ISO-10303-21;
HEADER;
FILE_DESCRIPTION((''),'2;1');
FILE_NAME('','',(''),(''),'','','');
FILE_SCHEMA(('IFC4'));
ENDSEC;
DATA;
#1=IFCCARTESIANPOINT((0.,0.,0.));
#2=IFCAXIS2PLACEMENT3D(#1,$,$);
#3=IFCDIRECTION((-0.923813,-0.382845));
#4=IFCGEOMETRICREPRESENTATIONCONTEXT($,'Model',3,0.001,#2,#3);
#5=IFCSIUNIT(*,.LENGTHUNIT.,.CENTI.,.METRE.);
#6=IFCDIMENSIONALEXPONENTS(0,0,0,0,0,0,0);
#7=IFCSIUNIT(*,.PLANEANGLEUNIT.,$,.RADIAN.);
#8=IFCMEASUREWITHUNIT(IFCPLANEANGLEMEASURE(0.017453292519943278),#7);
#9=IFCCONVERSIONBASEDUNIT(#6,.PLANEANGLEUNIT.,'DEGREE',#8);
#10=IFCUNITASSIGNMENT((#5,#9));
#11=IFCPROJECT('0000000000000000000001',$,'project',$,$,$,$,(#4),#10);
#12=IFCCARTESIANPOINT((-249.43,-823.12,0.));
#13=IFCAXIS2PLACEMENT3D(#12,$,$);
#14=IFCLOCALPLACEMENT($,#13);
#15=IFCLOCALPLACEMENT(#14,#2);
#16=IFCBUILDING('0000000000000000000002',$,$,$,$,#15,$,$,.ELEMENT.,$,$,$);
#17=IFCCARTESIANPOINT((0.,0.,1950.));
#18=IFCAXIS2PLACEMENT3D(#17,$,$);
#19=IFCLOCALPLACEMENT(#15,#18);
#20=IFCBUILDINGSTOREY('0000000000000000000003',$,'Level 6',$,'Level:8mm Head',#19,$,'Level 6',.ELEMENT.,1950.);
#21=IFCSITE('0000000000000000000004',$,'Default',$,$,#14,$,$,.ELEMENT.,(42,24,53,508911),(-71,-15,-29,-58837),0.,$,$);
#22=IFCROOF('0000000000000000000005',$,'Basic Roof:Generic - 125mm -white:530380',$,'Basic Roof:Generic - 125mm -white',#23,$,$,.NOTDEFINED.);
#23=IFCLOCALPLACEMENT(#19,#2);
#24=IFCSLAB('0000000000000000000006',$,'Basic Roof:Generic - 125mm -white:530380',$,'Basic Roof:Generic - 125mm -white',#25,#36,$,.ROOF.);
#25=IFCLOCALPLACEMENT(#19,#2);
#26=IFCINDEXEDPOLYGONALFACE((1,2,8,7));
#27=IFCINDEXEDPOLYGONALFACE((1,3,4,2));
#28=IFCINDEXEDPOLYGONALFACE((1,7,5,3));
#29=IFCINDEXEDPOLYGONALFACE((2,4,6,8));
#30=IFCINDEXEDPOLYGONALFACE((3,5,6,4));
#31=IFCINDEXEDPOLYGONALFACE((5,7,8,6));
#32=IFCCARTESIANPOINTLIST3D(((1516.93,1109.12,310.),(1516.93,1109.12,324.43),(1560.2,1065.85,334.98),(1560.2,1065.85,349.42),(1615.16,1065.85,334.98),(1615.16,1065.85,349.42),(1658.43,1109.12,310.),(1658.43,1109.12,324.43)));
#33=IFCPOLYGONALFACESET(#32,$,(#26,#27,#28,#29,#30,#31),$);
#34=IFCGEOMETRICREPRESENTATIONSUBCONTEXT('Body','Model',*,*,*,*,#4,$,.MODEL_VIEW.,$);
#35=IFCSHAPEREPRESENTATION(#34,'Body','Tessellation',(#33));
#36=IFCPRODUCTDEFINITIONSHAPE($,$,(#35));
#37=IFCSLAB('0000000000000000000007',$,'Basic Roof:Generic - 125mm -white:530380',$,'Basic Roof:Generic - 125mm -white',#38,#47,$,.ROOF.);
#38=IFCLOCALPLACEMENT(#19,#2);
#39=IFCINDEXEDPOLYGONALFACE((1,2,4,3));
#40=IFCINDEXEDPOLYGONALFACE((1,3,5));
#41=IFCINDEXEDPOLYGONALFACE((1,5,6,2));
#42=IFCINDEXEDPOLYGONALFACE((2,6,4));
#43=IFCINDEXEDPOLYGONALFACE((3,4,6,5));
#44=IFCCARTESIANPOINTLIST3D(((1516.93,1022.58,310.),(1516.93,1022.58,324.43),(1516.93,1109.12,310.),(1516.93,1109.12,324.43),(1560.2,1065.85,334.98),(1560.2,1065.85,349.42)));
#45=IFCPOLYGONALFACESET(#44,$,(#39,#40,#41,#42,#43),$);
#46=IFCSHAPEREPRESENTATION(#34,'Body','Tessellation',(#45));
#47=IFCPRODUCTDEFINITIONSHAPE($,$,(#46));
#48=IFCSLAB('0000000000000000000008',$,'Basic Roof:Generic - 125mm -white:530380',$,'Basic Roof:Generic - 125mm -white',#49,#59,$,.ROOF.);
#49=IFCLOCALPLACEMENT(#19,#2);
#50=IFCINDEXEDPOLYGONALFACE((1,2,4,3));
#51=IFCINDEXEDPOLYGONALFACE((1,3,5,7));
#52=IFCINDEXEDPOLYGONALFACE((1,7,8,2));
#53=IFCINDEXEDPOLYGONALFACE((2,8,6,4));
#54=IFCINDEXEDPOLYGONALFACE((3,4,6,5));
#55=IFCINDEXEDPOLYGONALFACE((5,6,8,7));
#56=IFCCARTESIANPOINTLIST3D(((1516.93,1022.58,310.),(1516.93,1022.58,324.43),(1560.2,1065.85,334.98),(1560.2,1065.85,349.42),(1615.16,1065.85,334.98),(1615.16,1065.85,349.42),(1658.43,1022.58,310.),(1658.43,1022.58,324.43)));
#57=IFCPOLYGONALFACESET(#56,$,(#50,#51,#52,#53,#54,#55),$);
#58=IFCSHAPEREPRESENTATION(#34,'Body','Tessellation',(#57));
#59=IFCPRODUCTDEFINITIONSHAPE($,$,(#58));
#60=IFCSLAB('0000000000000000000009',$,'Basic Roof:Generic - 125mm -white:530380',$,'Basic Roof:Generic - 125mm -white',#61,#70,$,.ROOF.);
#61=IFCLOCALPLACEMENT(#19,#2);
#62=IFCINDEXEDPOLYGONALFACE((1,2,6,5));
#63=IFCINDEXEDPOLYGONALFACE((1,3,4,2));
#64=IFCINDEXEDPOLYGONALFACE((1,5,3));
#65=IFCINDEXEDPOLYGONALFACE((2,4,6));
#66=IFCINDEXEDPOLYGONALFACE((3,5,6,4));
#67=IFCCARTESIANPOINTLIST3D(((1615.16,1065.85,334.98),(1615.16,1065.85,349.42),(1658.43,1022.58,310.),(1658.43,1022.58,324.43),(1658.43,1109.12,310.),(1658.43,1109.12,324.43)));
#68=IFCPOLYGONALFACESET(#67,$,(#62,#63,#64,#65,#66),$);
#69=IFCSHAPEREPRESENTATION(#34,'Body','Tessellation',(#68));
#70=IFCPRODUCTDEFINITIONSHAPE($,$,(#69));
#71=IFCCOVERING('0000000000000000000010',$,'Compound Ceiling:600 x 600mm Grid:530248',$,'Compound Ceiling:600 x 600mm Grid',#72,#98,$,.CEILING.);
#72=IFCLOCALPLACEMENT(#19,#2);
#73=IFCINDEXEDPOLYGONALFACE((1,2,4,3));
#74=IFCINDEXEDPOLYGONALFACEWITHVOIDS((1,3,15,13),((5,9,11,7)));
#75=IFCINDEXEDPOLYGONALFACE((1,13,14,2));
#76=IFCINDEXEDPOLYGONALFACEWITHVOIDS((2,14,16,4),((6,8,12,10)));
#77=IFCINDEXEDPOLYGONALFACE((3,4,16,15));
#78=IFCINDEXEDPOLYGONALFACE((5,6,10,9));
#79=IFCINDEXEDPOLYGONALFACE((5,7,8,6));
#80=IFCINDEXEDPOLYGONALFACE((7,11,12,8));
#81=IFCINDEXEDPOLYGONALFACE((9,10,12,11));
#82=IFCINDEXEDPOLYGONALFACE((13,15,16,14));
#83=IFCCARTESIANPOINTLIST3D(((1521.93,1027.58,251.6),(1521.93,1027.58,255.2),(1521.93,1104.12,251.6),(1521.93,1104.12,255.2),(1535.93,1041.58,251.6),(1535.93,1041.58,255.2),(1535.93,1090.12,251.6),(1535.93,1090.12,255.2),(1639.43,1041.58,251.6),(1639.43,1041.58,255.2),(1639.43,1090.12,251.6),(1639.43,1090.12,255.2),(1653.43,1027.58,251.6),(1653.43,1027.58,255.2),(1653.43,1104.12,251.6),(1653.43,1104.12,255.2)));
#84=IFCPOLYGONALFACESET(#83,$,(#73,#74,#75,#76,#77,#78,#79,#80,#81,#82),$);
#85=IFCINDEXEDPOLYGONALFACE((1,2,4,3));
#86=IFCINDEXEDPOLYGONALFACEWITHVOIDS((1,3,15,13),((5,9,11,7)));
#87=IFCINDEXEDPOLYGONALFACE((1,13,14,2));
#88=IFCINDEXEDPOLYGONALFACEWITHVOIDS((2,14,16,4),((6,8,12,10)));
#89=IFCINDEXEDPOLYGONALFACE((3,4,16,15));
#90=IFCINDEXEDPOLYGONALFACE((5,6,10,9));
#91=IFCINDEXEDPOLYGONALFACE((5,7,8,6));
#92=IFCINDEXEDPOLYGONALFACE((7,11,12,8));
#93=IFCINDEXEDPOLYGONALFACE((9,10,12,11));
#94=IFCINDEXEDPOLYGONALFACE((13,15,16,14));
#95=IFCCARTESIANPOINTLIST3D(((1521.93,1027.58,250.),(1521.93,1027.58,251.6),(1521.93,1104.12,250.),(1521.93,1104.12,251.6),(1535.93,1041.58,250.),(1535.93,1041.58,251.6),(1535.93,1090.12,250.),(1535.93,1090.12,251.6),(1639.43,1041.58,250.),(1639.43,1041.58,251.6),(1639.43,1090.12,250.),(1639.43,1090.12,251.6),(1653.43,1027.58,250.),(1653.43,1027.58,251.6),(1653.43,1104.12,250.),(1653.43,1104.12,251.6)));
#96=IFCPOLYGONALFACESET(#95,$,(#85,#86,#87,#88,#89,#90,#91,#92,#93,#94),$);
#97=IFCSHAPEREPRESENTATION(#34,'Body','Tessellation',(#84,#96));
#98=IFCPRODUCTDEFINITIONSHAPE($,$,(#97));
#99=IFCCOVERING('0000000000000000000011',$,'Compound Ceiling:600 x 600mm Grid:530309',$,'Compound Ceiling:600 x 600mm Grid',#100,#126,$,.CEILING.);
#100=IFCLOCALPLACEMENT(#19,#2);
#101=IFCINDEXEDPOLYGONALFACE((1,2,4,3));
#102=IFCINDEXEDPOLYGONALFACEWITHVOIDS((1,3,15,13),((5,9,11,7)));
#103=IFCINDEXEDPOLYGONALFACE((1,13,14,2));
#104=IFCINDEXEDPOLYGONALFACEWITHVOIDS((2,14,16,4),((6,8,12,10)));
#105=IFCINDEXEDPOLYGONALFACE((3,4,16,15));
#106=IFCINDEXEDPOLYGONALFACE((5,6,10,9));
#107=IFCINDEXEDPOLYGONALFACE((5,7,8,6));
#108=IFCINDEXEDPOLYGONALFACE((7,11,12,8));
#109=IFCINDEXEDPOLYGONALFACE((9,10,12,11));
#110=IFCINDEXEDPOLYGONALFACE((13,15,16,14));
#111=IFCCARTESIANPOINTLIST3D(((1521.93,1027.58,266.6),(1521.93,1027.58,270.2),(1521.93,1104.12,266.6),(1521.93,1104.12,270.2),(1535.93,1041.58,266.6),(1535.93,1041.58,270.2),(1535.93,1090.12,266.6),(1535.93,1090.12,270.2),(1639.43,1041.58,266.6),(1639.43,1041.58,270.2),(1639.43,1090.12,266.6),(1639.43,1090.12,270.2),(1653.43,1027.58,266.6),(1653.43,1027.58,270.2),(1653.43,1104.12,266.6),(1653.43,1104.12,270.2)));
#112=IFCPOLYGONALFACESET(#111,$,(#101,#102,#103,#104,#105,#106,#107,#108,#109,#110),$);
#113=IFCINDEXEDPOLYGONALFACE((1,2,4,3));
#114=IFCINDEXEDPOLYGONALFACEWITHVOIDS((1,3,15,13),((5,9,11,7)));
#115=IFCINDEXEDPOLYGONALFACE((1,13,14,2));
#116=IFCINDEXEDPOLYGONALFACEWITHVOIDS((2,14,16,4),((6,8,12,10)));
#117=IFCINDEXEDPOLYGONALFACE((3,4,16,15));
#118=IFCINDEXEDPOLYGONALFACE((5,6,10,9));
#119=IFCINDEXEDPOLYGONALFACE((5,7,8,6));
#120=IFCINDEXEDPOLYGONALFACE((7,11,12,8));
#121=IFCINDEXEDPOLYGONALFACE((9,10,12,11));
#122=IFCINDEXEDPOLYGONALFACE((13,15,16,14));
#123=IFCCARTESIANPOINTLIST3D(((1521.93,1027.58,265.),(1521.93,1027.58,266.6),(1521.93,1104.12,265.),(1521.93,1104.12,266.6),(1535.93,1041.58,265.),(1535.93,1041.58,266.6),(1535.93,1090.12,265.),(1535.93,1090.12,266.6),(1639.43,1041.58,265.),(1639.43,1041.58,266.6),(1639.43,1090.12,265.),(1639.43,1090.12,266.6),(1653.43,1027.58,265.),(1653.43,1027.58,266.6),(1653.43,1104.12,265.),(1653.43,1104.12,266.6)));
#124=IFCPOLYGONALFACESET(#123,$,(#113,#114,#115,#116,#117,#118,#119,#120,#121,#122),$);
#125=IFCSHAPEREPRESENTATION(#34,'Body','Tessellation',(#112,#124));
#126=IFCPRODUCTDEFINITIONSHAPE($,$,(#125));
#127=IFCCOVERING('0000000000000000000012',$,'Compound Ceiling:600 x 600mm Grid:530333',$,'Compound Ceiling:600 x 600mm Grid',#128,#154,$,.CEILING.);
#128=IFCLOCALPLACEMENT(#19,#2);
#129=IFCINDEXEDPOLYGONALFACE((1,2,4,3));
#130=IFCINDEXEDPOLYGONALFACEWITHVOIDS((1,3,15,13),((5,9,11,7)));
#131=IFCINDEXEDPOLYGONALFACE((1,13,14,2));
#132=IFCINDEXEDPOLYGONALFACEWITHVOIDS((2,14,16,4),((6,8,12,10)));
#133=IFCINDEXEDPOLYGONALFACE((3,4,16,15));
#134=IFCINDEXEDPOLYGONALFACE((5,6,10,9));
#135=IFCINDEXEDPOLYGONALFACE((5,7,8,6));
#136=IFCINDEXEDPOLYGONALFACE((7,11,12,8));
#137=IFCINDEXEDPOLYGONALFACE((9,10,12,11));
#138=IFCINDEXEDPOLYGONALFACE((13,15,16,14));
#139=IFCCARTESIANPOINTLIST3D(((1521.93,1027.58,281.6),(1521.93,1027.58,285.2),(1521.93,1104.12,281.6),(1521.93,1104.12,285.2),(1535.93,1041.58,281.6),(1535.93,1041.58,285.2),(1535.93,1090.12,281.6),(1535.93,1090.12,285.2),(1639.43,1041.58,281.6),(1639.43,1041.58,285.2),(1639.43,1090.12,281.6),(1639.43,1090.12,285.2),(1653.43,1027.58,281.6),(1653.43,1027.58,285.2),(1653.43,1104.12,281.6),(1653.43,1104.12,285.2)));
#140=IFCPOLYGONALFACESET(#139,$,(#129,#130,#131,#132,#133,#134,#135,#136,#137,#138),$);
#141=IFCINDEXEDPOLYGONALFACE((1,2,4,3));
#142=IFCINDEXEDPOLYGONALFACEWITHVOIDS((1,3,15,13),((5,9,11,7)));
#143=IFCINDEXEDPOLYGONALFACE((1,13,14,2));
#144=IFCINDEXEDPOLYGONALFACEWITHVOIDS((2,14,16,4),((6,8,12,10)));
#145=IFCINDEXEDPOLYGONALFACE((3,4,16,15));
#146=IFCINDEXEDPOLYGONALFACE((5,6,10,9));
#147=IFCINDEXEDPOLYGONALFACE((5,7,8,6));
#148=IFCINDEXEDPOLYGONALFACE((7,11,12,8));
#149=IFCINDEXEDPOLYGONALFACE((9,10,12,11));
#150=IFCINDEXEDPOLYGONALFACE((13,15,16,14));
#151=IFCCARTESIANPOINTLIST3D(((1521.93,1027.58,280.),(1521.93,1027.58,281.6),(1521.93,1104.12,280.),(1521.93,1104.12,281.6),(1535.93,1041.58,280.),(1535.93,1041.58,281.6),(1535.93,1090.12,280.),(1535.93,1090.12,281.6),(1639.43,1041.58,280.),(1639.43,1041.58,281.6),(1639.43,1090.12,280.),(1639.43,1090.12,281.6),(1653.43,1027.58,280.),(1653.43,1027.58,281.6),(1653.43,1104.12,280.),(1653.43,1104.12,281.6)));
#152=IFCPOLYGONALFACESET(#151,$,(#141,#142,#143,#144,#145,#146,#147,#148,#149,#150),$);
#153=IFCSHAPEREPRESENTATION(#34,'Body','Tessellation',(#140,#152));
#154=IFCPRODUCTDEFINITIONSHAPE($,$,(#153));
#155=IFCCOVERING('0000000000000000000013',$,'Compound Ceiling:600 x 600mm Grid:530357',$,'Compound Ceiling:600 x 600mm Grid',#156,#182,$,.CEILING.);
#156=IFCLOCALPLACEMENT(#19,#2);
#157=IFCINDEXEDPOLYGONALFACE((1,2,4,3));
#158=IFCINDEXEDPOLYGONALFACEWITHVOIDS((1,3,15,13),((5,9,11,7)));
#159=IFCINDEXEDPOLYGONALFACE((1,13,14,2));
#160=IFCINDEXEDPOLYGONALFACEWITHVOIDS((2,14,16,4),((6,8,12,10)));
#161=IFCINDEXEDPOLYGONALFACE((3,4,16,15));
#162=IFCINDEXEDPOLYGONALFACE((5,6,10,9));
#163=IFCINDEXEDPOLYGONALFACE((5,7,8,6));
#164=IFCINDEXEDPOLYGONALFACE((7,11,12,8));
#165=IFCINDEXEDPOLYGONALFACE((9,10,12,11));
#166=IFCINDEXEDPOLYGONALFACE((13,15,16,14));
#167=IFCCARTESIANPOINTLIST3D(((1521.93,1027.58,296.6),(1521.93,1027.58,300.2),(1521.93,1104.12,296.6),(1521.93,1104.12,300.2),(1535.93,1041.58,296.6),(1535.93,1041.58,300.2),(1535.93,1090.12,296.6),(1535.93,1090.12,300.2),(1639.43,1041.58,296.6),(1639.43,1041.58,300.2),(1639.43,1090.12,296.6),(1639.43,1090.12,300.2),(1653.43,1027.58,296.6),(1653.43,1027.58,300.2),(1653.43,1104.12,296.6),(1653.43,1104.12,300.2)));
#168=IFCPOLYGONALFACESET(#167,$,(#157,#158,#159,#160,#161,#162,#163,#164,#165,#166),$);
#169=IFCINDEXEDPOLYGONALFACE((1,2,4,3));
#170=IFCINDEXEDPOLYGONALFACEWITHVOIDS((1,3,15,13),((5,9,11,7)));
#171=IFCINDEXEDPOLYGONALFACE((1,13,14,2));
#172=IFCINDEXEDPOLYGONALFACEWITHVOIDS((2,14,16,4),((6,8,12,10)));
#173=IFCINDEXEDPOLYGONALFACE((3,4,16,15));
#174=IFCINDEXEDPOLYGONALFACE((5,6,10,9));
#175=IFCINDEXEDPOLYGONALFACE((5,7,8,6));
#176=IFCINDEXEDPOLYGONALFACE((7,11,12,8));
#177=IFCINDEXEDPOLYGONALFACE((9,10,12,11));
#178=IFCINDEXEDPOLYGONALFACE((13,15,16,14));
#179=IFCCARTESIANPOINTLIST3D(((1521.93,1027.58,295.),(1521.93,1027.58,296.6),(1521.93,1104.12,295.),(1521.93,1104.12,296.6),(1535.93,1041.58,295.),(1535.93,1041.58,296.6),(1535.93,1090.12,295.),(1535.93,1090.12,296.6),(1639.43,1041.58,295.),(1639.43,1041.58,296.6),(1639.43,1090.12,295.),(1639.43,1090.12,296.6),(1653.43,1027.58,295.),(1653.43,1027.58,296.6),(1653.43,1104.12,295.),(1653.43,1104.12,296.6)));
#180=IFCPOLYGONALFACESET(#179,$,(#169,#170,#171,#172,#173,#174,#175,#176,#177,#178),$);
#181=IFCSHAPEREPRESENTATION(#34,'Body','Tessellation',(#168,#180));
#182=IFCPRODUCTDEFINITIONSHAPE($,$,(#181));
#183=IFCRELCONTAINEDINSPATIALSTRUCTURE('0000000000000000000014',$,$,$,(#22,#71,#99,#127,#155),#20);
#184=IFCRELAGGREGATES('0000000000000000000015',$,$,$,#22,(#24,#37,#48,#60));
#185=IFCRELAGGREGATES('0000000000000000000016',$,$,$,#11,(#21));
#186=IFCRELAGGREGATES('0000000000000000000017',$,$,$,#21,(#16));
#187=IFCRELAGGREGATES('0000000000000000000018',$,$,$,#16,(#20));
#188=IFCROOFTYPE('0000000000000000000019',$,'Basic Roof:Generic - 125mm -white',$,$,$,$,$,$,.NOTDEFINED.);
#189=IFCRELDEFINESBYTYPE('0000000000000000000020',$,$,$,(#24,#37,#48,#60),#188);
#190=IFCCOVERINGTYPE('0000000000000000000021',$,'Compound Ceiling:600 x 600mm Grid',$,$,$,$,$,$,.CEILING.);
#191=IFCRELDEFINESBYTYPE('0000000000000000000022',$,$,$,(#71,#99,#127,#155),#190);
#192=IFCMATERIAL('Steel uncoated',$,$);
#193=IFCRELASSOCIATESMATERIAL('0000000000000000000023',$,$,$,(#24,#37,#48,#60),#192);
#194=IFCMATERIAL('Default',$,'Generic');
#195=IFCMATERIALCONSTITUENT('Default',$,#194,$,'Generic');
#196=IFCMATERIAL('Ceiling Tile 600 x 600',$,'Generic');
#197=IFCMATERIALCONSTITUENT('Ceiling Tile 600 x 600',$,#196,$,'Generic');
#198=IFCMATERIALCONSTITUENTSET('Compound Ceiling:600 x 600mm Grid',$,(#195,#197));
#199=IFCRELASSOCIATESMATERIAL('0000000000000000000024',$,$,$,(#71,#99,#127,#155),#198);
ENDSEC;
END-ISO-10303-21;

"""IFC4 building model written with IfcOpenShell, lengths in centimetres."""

from ifc_helpers import new_model, entity, si_unit, converted_unit, direction, frame, origin, place, context, subcontext, project, spatial, indexed_curve, outline, extrude, material, constituent, constituent_set, type_object, element, aggregate, save


model = new_model("IFC4")

# Units and contexts
model_context = context("Model", 3, precision=0.001, world=origin(), true_north=direction((-0.923813, -0.382845)))
body_context = subcontext(model_context, "Body", "Model", "MODEL_VIEW")
ifc_project = project(units=[si_unit("LENGTHUNIT", "METRE", prefix="CENTI"), converted_unit("PLANEANGLEUNIT", "DEGREE", entity("IfcPlaneAngleMeasure", 0.017453292519943278), si_unit("PLANEANGLEUNIT", "RADIAN"), dimensions=[0, 0, 0, 0, 0, 0, 0])], contexts=[model_context])

# Site, building, storey
site_placement = place(None, frame((-249.43, -823.12, 0.0)))
site = spatial("IfcSite", under=ifc_project, at=site_placement, Name="Default", CompositionType="ELEMENT", RefLatitude=(42, 24, 53, 508911), RefLongitude=(-71, -15, -29, -58837), RefElevation=0.0)
building_placement = place(site_placement, origin())
building = spatial("IfcBuilding", under=site, at=building_placement, CompositionType="ELEMENT")
storey_placement = place(building_placement, frame((0.0, 0.0, 1950.0)))
storey = spatial("IfcBuildingStorey", under=building, at=storey_placement, Name="Level 6", ObjectType="Level:8mm Head", LongName="Level 6", CompositionType="ELEMENT", Elevation=1950.0)

# Roof, slabs
roof_placement = place(storey_placement, frame((1516.93, 1022.58, 310.0)))
roof = element("IfcRoof", 1, at=roof_placement, inside=storey, Name="Basic Roof:Generic - 125mm -white:530380", ObjectType="Basic Roof:Generic - 125mm -white", PredefinedType="NOTDEFINED")
ifc_material_1 = material(Name="Steel uncoated")
roof_type = type_object("IfcRoofType", Name="Basic Roof:Generic - 125mm -white", PredefinedType="NOTDEFINED")
slab_1_placement = place(roof_placement, origin())
slab_1 = element("IfcSlab", 2, at=slab_1_placement, type_object=roof_type, material=ifc_material_1, Name="Basic Roof:Generic - 125mm -white:530380", ObjectType="Basic Roof:Generic - 125mm -white", PredefinedType="ROOF", context=body_context, shape_type="SweptSolid", body=[
    extrude(outline(indexed_curve([(70.75, 24.98), (-70.75, 24.98), (-27.48, -24.98), (27.48, -24.98), (70.75, 24.98)], self_intersect=False)), frame((70.75, 64.9, 12.49), z_axis=(0.0, 0.5, 0.866025), x_axis=(1.0, 0.0, 0.0)), (0.0, -0.5, 0.866025), 14.43),
])
slab_2_placement = place(roof_placement, origin())
slab_2 = element("IfcSlab", 3, at=slab_2_placement, type_object=roof_type, material=ifc_material_1, Name="Basic Roof:Generic - 125mm -white:530380", ObjectType="Basic Roof:Generic - 125mm -white", PredefinedType="ROOF", context=body_context, shape_type="SweptSolid", body=[
    extrude(outline(indexed_curve([(-24.98, 43.27), (-24.98, -43.27), (24.98, 0.0), (-24.98, 43.27)], self_intersect=False)), frame((21.64, 43.27, 12.49), z_axis=(-0.5, 0.0, 0.866025), x_axis=(0.866025, 0.0, 0.5)), (0.5, 0.0, 0.866025), 14.43),
])
slab_3_placement = place(roof_placement, origin())
slab_3 = element("IfcSlab", 4, at=slab_3_placement, type_object=roof_type, material=ifc_material_1, Name="Basic Roof:Generic - 125mm -white:530380", ObjectType="Basic Roof:Generic - 125mm -white", PredefinedType="ROOF", context=body_context, shape_type="SweptSolid", body=[
    extrude(outline(indexed_curve([(-70.75, -24.98), (70.75, -24.98), (27.48, 24.98), (-27.48, 24.98), (-70.75, -24.98)], self_intersect=False)), frame((70.75, 21.64, 12.49), z_axis=(0.0, -0.5, 0.866025), x_axis=(1.0, 0.0, 0.0)), (0.0, 0.5, 0.866025), 14.43),
])
slab_4_placement = place(roof_placement, origin())
slab_4 = element("IfcSlab", 5, at=slab_4_placement, type_object=roof_type, material=ifc_material_1, Name="Basic Roof:Generic - 125mm -white:530380", ObjectType="Basic Roof:Generic - 125mm -white", PredefinedType="ROOF", context=body_context, shape_type="SweptSolid", body=[
    extrude(outline(indexed_curve([(-24.98, 0.0), (24.98, -43.27), (24.98, 43.27), (-24.98, 0.0)], self_intersect=False)), frame((119.87, 43.27, 12.49), z_axis=(0.5, 0.0, 0.866025), x_axis=(0.866025, 0.0, -0.5)), (-0.5, 0.0, 0.866025), 14.43),
])
aggregate(roof, [slab_1, slab_2, slab_3, slab_4])

# Coverings
ifc_material_2 = material(Name="Default", Category="Generic")
ifc_constituent_1 = constituent(ifc_material_2, Name="Default", Category="Generic")
ifc_material_3 = material(Name="Ceiling Tile 600 x 600", Category="Generic")
ifc_constituent_2 = constituent(ifc_material_3, Name="Ceiling Tile 600 x 600", Category="Generic")
ifc_constituent_set_1 = constituent_set(constituents=[ifc_constituent_1, ifc_constituent_2], Name="Compound Ceiling:600 x 600mm Grid")
covering_type = type_object("IfcCoveringType", Name="Compound Ceiling:600 x 600mm Grid", PredefinedType="CEILING")
for number, where, name in (
    (6, (1521.93, 1027.58, 250.0), "Compound Ceiling:600 x 600mm Grid:530248"),
    (7, (1521.93, 1027.58, 265.0), "Compound Ceiling:600 x 600mm Grid:530309"),
    (8, (1521.93, 1027.58, 280.0), "Compound Ceiling:600 x 600mm Grid:530333"),
):
    element("IfcCovering", number, at=place(storey_placement, frame(where)), inside=storey, type_object=covering_type, material=ifc_constituent_set_1, Name=name, ObjectType="Compound Ceiling:600 x 600mm Grid", PredefinedType="CEILING", context=body_context, shape_type="SweptSolid", body=[
        extrude(outline(indexed_curve([(-38.27, -65.75), (38.27, -65.75), (38.27, 65.75), (-38.27, 65.75), (-38.27, -65.75)], self_intersect=False), holes=[indexed_curve([(24.27, -51.75), (-24.27, -51.75), (-24.27, 51.75), (24.27, 51.75), (24.27, -51.75)], self_intersect=False)]), frame((65.75, 38.27, 1.6), z_axis=(0.0, 0.0, 1.0), x_axis=(0.0, -1.0, 0.0)), (0.0, 0.0, 1.0), 3.6),
        extrude(outline(indexed_curve([(-65.75, -38.27), (65.75, -38.27), (65.75, 38.27), (-65.75, 38.27), (-65.75, -38.27)], self_intersect=False), holes=[indexed_curve([(-51.75, 24.27), (51.75, 24.27), (51.75, -24.27), (-51.75, -24.27), (-51.75, 24.27)], self_intersect=False)]), frame((65.75, 38.27, 0.0), z_axis=(0.0, 0.0, 1.0), x_axis=(-1.0, 0.0, 0.0)), (0.0, 0.0, 1.0), 1.6),
    ])
covering_placement = place(storey_placement, frame((1521.93, 1027.58, 295.0)))
element("IfcCovering", 9, at=covering_placement, inside=storey, type_object=covering_type, material=ifc_constituent_set_1, Name="Compound Ceiling:600 x 600mm Grid:530357", ObjectType="Compound Ceiling:600 x 600mm Grid", PredefinedType="CEILING", context=body_context, shape_type="SweptSolid", body=[
    extrude(outline(indexed_curve([(-38.27, -65.75), (38.27, -65.75), (38.27, 65.75), (-38.27, 65.75), (-38.27, -65.75)], self_intersect=False), holes=[indexed_curve([(24.27, -51.75), (-24.27, -51.75), (-24.27, 51.75), (24.27, 51.75), (24.27, -51.75)], self_intersect=False)]), frame((65.75, 38.27, 1.6), z_axis=(0.0, 0.0, 1.0), x_axis=(0.0, -1.0, 0.0)), (0.0, 0.0, 1.0), 3.6),
    extrude(outline(indexed_curve([(-65.75, -38.27), (65.75, -38.27), (65.75, 38.27), (-65.75, 38.27), (-65.75, -38.27)], self_intersect=False), holes=[indexed_curve([(-51.75, 24.27), (51.75, 24.27), (51.75, -24.27), (-51.75, -24.27), (-51.75, 24.27)], self_intersect=False)]), frame((65.75, 38.27, 0.0), z_axis=(0.0, 0.0, 1.0), x_axis=(-1.0, 0.0, 0.0)), (0.0, 0.0, 1.0), 1.6),
])

save(model, "model.ifc")
